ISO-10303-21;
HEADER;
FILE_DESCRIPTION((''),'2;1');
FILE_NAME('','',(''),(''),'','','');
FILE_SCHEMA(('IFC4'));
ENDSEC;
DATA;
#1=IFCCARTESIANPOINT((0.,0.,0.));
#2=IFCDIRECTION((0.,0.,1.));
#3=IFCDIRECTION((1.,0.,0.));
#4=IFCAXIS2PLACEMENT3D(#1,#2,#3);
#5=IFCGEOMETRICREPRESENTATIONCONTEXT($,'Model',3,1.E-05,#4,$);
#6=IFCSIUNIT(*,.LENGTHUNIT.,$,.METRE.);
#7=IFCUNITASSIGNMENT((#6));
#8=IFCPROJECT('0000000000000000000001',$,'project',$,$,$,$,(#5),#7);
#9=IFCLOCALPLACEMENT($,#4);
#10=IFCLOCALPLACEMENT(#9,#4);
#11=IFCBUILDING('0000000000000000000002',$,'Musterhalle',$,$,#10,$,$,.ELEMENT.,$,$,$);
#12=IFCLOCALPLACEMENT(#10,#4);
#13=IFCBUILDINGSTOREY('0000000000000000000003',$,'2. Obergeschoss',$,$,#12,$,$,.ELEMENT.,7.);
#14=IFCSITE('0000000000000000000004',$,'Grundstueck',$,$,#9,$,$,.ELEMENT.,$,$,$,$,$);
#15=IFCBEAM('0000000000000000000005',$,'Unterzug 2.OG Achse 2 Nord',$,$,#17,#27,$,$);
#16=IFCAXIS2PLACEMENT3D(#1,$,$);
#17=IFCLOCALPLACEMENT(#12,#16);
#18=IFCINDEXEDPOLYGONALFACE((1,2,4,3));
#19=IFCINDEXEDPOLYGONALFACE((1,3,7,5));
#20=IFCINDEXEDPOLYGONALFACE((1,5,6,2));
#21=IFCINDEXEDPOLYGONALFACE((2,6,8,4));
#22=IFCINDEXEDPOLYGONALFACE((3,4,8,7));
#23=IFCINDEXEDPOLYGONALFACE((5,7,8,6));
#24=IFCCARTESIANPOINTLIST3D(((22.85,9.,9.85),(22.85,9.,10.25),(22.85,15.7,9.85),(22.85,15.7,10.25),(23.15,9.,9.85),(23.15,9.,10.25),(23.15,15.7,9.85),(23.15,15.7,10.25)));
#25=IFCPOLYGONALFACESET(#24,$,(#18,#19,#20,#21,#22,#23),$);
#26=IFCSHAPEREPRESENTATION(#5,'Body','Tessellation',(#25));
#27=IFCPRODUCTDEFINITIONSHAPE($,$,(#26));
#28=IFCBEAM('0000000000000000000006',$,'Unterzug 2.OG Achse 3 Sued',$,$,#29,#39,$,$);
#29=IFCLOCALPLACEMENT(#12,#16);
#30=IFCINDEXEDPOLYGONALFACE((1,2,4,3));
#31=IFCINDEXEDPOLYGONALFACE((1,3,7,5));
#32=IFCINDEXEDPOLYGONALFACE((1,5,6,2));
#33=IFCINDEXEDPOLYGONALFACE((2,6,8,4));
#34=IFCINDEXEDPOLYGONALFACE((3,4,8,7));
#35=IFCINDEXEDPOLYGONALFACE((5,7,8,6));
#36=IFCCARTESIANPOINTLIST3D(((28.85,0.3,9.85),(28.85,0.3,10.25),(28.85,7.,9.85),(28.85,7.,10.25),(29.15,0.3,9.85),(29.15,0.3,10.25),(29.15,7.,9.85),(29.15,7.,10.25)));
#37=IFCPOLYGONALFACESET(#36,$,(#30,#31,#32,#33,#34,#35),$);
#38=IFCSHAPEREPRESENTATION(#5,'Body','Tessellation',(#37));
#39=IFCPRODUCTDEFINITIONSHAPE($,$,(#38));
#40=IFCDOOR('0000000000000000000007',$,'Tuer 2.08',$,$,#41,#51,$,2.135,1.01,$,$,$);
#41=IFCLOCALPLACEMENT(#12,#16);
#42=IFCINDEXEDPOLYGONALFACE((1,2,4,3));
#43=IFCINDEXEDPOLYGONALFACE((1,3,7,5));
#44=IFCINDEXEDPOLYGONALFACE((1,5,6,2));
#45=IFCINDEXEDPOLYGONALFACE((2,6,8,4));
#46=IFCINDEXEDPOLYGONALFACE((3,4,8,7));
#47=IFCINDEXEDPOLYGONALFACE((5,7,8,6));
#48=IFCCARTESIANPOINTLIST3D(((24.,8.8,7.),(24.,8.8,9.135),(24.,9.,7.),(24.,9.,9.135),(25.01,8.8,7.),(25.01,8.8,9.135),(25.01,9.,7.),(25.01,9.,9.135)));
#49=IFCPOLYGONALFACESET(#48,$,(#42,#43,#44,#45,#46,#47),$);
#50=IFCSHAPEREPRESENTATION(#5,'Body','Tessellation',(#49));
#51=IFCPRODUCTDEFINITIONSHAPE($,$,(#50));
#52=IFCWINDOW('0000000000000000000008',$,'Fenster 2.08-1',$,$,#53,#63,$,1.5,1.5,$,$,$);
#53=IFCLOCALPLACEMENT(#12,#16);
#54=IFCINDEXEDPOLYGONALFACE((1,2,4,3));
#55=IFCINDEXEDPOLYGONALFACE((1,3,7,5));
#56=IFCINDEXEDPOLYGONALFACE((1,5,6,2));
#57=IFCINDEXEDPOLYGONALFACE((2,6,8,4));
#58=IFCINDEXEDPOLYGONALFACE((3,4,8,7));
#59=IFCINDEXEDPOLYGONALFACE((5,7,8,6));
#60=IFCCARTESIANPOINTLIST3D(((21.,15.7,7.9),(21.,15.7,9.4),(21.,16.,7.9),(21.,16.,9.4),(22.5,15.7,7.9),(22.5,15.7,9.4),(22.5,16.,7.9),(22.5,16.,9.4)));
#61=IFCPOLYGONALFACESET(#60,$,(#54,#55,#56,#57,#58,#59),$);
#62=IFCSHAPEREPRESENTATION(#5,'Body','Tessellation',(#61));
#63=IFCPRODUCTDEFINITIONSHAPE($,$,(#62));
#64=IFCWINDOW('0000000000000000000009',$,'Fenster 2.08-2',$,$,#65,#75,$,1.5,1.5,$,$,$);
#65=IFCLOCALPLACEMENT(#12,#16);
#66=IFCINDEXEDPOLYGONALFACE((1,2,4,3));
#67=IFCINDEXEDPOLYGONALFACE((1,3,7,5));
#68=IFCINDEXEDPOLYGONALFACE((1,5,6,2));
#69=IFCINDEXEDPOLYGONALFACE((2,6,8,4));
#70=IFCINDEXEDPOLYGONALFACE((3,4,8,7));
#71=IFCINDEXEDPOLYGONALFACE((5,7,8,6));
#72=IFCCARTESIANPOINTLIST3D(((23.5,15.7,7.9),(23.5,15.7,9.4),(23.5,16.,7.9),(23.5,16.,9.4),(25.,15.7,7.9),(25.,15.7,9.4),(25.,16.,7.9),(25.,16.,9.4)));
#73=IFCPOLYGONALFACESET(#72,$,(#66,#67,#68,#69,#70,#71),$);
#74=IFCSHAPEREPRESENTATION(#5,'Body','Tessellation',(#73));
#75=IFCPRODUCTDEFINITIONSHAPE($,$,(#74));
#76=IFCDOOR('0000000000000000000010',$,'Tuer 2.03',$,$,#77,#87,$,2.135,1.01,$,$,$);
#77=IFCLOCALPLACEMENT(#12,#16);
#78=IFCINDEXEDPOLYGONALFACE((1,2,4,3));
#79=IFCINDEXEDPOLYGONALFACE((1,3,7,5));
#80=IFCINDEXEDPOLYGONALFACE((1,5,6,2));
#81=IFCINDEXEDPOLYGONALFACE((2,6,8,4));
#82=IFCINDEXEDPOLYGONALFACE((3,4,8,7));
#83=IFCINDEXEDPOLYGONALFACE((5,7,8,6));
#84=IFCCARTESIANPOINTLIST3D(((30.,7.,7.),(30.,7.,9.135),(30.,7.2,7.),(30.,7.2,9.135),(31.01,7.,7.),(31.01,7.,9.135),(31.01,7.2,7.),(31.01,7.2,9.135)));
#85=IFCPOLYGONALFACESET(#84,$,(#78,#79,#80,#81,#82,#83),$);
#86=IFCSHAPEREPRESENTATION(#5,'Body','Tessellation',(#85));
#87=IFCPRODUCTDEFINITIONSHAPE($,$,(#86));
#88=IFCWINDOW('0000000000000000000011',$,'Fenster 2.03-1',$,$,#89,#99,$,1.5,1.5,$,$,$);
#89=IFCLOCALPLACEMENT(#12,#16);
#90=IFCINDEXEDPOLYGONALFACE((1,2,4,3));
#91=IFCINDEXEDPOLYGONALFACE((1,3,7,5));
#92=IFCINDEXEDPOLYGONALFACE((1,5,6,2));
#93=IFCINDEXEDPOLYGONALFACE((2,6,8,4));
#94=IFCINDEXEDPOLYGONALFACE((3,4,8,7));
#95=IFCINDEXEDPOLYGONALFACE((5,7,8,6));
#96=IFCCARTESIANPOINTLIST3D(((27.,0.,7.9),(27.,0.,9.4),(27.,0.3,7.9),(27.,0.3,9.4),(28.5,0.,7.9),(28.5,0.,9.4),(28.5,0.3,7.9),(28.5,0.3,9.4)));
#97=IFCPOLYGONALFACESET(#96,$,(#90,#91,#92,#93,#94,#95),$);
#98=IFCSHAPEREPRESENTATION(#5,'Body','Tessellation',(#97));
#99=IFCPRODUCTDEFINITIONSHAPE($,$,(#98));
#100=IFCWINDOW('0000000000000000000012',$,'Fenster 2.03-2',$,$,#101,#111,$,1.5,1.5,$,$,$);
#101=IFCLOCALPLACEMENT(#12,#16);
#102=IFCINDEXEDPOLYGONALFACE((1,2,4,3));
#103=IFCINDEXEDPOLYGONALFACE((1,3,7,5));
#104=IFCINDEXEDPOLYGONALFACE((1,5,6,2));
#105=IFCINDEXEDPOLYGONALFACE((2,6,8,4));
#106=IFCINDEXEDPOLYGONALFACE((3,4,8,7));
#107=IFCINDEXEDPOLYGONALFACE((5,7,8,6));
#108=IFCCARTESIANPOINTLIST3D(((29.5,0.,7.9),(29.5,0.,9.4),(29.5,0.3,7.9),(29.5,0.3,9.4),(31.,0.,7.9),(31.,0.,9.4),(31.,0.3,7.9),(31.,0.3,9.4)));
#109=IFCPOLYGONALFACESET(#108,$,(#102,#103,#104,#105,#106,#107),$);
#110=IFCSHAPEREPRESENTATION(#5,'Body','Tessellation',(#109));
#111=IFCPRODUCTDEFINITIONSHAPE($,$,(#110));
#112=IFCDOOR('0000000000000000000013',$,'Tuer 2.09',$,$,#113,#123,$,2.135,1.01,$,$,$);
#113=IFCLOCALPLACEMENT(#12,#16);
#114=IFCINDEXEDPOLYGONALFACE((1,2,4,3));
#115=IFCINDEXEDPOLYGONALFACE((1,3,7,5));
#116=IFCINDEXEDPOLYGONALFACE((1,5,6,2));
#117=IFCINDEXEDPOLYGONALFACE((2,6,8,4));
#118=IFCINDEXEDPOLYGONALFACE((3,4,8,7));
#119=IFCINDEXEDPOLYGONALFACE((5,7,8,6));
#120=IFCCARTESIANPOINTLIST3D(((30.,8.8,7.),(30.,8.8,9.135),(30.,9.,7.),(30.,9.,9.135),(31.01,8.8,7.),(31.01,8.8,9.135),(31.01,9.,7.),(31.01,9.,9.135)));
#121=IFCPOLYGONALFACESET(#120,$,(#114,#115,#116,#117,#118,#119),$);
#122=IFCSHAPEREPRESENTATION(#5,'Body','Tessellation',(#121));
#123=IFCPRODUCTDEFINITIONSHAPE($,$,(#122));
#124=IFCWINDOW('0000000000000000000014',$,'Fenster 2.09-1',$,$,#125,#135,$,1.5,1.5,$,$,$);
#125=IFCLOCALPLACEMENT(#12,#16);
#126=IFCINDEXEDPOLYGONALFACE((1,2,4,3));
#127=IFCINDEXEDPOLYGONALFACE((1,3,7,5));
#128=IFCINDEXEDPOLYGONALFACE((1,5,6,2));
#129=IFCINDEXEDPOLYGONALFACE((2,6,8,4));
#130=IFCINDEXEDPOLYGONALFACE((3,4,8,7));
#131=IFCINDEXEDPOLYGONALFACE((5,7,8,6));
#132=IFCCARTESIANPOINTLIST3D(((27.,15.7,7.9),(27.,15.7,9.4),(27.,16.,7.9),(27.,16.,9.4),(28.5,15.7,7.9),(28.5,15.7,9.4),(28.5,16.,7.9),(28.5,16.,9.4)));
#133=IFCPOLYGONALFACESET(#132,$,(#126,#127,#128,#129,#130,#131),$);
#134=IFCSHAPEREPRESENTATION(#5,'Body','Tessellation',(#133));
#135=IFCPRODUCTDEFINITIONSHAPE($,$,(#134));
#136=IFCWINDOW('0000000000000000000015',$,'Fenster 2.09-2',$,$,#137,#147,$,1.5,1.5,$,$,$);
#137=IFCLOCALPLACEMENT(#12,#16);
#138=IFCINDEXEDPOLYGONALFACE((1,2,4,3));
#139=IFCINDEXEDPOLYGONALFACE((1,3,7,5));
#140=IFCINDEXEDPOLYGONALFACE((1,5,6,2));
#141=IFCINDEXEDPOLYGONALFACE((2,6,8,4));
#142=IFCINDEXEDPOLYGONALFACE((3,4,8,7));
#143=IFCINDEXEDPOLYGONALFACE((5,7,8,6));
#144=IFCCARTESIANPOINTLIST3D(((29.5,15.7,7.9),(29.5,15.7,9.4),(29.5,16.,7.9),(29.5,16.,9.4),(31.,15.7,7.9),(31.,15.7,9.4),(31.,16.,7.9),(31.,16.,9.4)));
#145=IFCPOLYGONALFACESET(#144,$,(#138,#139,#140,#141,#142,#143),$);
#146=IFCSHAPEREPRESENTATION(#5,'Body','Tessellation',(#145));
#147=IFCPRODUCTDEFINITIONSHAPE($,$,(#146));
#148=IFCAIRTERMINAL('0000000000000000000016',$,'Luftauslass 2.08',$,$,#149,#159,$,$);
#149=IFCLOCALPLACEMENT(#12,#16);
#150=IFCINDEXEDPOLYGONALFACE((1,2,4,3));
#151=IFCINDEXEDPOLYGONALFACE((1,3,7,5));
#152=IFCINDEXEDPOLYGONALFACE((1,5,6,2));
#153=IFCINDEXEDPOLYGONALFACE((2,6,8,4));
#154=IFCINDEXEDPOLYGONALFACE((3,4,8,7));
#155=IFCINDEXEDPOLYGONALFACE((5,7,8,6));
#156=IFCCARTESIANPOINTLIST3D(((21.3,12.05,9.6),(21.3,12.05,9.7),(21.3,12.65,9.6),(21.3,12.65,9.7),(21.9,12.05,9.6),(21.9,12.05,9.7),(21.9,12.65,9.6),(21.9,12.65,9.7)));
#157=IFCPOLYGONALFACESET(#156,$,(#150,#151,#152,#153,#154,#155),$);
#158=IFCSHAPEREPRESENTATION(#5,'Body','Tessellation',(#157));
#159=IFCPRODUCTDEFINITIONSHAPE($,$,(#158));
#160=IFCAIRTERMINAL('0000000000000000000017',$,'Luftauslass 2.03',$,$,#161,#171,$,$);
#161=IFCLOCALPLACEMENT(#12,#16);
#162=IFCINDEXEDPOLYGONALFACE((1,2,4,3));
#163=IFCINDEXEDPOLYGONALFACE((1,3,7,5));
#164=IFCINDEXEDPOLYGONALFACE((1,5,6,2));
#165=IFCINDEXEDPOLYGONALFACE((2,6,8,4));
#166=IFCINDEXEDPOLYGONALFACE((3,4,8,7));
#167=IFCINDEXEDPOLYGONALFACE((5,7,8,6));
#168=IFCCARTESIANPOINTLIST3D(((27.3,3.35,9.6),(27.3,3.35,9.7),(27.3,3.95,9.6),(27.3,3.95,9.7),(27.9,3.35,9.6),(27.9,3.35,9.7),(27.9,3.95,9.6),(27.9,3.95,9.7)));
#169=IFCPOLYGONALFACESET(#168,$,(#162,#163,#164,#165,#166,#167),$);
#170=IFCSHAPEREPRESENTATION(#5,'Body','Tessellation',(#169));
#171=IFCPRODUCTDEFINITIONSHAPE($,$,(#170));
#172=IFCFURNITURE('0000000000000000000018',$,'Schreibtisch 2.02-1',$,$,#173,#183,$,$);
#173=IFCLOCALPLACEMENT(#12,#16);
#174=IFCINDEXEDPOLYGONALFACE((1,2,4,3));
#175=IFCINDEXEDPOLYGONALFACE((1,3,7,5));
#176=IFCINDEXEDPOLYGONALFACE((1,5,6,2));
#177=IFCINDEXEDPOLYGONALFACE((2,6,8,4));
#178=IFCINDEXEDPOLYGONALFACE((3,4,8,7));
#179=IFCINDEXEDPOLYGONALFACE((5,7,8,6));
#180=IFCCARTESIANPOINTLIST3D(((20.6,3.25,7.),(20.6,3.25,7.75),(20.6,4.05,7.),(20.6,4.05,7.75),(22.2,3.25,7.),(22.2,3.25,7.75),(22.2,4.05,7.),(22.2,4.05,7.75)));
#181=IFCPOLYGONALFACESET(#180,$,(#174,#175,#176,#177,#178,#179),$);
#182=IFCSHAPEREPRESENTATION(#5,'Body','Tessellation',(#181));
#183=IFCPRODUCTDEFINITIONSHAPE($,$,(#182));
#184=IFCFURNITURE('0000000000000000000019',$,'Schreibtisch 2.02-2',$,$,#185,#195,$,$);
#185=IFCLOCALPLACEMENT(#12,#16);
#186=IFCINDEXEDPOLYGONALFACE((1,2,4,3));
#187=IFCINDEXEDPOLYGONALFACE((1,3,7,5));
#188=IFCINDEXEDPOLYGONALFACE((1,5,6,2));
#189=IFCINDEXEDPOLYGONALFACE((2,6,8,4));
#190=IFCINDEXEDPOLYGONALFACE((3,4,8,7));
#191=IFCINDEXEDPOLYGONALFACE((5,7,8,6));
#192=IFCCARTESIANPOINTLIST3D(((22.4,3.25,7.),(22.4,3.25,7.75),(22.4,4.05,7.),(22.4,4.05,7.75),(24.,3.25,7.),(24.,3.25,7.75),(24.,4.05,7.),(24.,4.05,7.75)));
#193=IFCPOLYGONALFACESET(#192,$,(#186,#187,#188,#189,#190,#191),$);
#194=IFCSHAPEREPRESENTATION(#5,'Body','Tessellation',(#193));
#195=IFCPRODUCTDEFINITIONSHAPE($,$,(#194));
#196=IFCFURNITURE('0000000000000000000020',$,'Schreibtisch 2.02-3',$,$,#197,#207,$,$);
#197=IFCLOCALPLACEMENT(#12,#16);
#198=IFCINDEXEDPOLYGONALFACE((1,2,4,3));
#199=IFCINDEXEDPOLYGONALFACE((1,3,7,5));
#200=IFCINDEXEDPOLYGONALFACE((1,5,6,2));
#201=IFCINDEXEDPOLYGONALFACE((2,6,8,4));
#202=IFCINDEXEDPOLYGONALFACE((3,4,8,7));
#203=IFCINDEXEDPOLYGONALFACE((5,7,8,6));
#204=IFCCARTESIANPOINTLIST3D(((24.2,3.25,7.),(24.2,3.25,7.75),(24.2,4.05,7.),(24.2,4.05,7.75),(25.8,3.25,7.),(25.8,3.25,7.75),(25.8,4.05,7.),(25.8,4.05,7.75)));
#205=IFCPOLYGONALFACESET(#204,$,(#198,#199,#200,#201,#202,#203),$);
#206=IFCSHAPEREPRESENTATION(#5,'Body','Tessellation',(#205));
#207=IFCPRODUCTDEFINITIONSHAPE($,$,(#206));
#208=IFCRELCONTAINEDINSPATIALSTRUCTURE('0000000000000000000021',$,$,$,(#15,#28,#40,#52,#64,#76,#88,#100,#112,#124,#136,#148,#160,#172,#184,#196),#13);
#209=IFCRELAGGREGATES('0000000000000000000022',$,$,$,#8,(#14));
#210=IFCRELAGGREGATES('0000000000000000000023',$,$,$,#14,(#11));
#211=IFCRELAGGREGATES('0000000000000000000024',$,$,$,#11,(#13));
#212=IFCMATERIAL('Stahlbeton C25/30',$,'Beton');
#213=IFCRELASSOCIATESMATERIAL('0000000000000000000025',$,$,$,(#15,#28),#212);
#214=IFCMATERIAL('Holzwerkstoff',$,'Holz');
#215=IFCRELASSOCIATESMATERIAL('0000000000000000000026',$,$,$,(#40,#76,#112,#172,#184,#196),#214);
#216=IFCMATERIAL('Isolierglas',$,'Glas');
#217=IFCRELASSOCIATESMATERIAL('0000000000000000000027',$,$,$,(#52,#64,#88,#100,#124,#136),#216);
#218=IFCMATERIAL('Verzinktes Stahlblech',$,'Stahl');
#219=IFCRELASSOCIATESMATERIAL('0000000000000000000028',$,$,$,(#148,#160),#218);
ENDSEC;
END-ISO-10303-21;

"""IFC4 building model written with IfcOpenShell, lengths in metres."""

from ifc_helpers import new_model, si_unit, frame, origin_with_axes, origin_2d, place, context, project, spatial, rectangle, extrude, material, element, save


model = new_model("IFC4")

# Units and contexts
model_context = context("Model", 3, precision=1e-05, world=origin_with_axes())
ifc_project = project(units=[si_unit("LENGTHUNIT", "METRE")], contexts=[model_context])

# Site, building, storey
site_placement = place(None, origin_with_axes())
site = spatial("IfcSite", under=ifc_project, at=site_placement, Name="Grundstueck", CompositionType="ELEMENT")
building_placement = place(site_placement, origin_with_axes())
building = spatial("IfcBuilding", under=site, at=building_placement, Name="Musterhalle", CompositionType="ELEMENT")
storey_placement = place(building_placement, origin_with_axes())
storey = spatial("IfcBuildingStorey", under=building, at=storey_placement, Name="2. Obergeschoss", CompositionType="ELEMENT", Elevation=7.0)

# Beams
ifc_material_1 = material(Name="Stahlbeton C25/30", Category="Beton")
placement = place(storey_placement, origin_with_axes())
element("IfcBeam", 1, at=placement, inside=storey, material=ifc_material_1, Name="Unterzug 2.OG Achse 2 Nord", context=model_context, shape_type="SweptSolid", body=[
    extrude(rectangle(XDim=0.3, YDim=6.7, at=origin_2d()), frame((23.0, 12.35, 9.85), z_axis=(0.0, 0.0, 1.0), x_axis=(1.0, 0.0, 0.0)), (0.0, 0.0, 1.0), 0.4),
])
element("IfcBeam", 2, at=placement, inside=storey, material=ifc_material_1, Name="Unterzug 2.OG Achse 3 Sued", context=model_context, shape_type="SweptSolid", body=[
    extrude(rectangle(XDim=0.3, YDim=6.7, at=origin_2d()), frame((29.0, 3.65, 9.85), z_axis=(0.0, 0.0, 1.0), x_axis=(1.0, 0.0, 0.0)), (0.0, 0.0, 1.0), 0.4),
])

# Door
ifc_material_2 = material(Name="Holzwerkstoff", Category="Holz")
element("IfcDoor", 3, at=placement, inside=storey, material=ifc_material_2, Name="Tuer 2.08", OverallHeight=2.135, OverallWidth=1.01, context=model_context, shape_type="SweptSolid", body=[
    extrude(rectangle(XDim=1.01, YDim=0.2, at=origin_2d()), frame((24.505, 8.9, 7.0), z_axis=(0.0, 0.0, 1.0), x_axis=(1.0, 0.0, 0.0)), (0.0, 0.0, 1.0), 2.135),
])

# Windows
ifc_material_3 = material(Name="Isolierglas", Category="Glas")
element("IfcWindow", 4, at=placement, inside=storey, material=ifc_material_3, Name="Fenster 2.08-1", OverallHeight=1.5, OverallWidth=1.5, context=model_context, shape_type="SweptSolid", body=[
    extrude(rectangle(XDim=1.5, YDim=0.3, at=origin_2d()), frame((21.75, 15.85, 7.9), z_axis=(0.0, 0.0, 1.0), x_axis=(1.0, 0.0, 0.0)), (0.0, 0.0, 1.0), 1.5),
])
element("IfcWindow", 5, at=placement, inside=storey, material=ifc_material_3, Name="Fenster 2.08-2", OverallHeight=1.5, OverallWidth=1.5, context=model_context, shape_type="SweptSolid", body=[
    extrude(rectangle(XDim=1.5, YDim=0.3, at=origin_2d()), frame((24.25, 15.85, 7.9), z_axis=(0.0, 0.0, 1.0), x_axis=(1.0, 0.0, 0.0)), (0.0, 0.0, 1.0), 1.5),
])

# Door
element("IfcDoor", 6, at=placement, inside=storey, material=ifc_material_2, Name="Tuer 2.03", OverallHeight=2.135, OverallWidth=1.01, context=model_context, shape_type="SweptSolid", body=[
    extrude(rectangle(XDim=1.01, YDim=0.2, at=origin_2d()), frame((30.505, 7.1, 7.0), z_axis=(0.0, 0.0, 1.0), x_axis=(1.0, 0.0, 0.0)), (0.0, 0.0, 1.0), 2.135),
])

# Windows
element("IfcWindow", 7, at=placement, inside=storey, material=ifc_material_3, Name="Fenster 2.03-1", OverallHeight=1.5, OverallWidth=1.5, context=model_context, shape_type="SweptSolid", body=[
    extrude(rectangle(XDim=1.5, YDim=0.3, at=origin_2d()), frame((27.75, 0.15, 7.9), z_axis=(0.0, 0.0, 1.0), x_axis=(1.0, 0.0, 0.0)), (0.0, 0.0, 1.0), 1.5),
])
element("IfcWindow", 8, at=placement, inside=storey, material=ifc_material_3, Name="Fenster 2.03-2", OverallHeight=1.5, OverallWidth=1.5, context=model_context, shape_type="SweptSolid", body=[
    extrude(rectangle(XDim=1.5, YDim=0.3, at=origin_2d()), frame((30.25, 0.15, 7.9), z_axis=(0.0, 0.0, 1.0), x_axis=(1.0, 0.0, 0.0)), (0.0, 0.0, 1.0), 1.5),
])

# Door
element("IfcDoor", 9, at=placement, inside=storey, material=ifc_material_2, Name="Tuer 2.09", OverallHeight=2.135, OverallWidth=1.01, context=model_context, shape_type="SweptSolid", body=[
    extrude(rectangle(XDim=1.01, YDim=0.2, at=origin_2d()), frame((30.505, 8.9, 7.0), z_axis=(0.0, 0.0, 1.0), x_axis=(1.0, 0.0, 0.0)), (0.0, 0.0, 1.0), 2.135),
])

# Windows
element("IfcWindow", 10, at=placement, inside=storey, material=ifc_material_3, Name="Fenster 2.09-1", OverallHeight=1.5, OverallWidth=1.5, context=model_context, shape_type="SweptSolid", body=[
    extrude(rectangle(XDim=1.5, YDim=0.3, at=origin_2d()), frame((27.75, 15.85, 7.9), z_axis=(0.0, 0.0, 1.0), x_axis=(1.0, 0.0, 0.0)), (0.0, 0.0, 1.0), 1.5),
])
element("IfcWindow", 11, at=placement, inside=storey, material=ifc_material_3, Name="Fenster 2.09-2", OverallHeight=1.5, OverallWidth=1.5, context=model_context, shape_type="SweptSolid", body=[
    extrude(rectangle(XDim=1.5, YDim=0.3, at=origin_2d()), frame((30.25, 15.85, 7.9), z_axis=(0.0, 0.0, 1.0), x_axis=(1.0, 0.0, 0.0)), (0.0, 0.0, 1.0), 1.5),
])

# Air terminals
ifc_material_4 = material(Name="Verzinktes Stahlblech", Category="Stahl")
element("IfcAirTerminal", 12, at=placement, inside=storey, material=ifc_material_4, Name="Luftauslass 2.08", context=model_context, shape_type="SweptSolid", body=[
    extrude(rectangle(XDim=0.6, YDim=0.6, at=origin_2d()), frame((21.6, 12.35, 9.6), z_axis=(0.0, 0.0, 1.0), x_axis=(1.0, 0.0, 0.0)), (0.0, 0.0, 1.0), 0.1),
])
element("IfcAirTerminal", 13, at=placement, inside=storey, material=ifc_material_4, Name="Luftauslass 2.03", context=model_context, shape_type="SweptSolid", body=[
    extrude(rectangle(XDim=0.6, YDim=0.6, at=origin_2d()), frame((27.6, 3.65, 9.6), z_axis=(0.0, 0.0, 1.0), x_axis=(1.0, 0.0, 0.0)), (0.0, 0.0, 1.0), 0.1),
])

# Furniture
element("IfcFurniture", 14, at=placement, inside=storey, material=ifc_material_2, Name="Schreibtisch 2.02-1", context=model_context, shape_type="SweptSolid", body=[
    extrude(rectangle(XDim=1.6, YDim=0.8, at=origin_2d()), frame((21.4, 3.65, 7.0), z_axis=(0.0, 0.0, 1.0), x_axis=(1.0, 0.0, 0.0)), (0.0, 0.0, 1.0), 0.75),
])
element("IfcFurniture", 15, at=placement, inside=storey, material=ifc_material_2, Name="Schreibtisch 2.02-2", context=model_context, shape_type="SweptSolid", body=[
    extrude(rectangle(XDim=1.6, YDim=0.8, at=origin_2d()), frame((23.2, 3.65, 7.0), z_axis=(0.0, 0.0, 1.0), x_axis=(1.0, 0.0, 0.0)), (0.0, 0.0, 1.0), 0.75),
])
element("IfcFurniture", 16, at=placement, inside=storey, material=ifc_material_2, Name="Schreibtisch 2.02-3", context=model_context, shape_type="SweptSolid", body=[
    extrude(rectangle(XDim=1.6, YDim=0.8, at=origin_2d()), frame((25.0, 3.65, 7.0), z_axis=(0.0, 0.0, 1.0), x_axis=(1.0, 0.0, 0.0)), (0.0, 0.0, 1.0), 0.75),
])

save(model, "model.ifc")
